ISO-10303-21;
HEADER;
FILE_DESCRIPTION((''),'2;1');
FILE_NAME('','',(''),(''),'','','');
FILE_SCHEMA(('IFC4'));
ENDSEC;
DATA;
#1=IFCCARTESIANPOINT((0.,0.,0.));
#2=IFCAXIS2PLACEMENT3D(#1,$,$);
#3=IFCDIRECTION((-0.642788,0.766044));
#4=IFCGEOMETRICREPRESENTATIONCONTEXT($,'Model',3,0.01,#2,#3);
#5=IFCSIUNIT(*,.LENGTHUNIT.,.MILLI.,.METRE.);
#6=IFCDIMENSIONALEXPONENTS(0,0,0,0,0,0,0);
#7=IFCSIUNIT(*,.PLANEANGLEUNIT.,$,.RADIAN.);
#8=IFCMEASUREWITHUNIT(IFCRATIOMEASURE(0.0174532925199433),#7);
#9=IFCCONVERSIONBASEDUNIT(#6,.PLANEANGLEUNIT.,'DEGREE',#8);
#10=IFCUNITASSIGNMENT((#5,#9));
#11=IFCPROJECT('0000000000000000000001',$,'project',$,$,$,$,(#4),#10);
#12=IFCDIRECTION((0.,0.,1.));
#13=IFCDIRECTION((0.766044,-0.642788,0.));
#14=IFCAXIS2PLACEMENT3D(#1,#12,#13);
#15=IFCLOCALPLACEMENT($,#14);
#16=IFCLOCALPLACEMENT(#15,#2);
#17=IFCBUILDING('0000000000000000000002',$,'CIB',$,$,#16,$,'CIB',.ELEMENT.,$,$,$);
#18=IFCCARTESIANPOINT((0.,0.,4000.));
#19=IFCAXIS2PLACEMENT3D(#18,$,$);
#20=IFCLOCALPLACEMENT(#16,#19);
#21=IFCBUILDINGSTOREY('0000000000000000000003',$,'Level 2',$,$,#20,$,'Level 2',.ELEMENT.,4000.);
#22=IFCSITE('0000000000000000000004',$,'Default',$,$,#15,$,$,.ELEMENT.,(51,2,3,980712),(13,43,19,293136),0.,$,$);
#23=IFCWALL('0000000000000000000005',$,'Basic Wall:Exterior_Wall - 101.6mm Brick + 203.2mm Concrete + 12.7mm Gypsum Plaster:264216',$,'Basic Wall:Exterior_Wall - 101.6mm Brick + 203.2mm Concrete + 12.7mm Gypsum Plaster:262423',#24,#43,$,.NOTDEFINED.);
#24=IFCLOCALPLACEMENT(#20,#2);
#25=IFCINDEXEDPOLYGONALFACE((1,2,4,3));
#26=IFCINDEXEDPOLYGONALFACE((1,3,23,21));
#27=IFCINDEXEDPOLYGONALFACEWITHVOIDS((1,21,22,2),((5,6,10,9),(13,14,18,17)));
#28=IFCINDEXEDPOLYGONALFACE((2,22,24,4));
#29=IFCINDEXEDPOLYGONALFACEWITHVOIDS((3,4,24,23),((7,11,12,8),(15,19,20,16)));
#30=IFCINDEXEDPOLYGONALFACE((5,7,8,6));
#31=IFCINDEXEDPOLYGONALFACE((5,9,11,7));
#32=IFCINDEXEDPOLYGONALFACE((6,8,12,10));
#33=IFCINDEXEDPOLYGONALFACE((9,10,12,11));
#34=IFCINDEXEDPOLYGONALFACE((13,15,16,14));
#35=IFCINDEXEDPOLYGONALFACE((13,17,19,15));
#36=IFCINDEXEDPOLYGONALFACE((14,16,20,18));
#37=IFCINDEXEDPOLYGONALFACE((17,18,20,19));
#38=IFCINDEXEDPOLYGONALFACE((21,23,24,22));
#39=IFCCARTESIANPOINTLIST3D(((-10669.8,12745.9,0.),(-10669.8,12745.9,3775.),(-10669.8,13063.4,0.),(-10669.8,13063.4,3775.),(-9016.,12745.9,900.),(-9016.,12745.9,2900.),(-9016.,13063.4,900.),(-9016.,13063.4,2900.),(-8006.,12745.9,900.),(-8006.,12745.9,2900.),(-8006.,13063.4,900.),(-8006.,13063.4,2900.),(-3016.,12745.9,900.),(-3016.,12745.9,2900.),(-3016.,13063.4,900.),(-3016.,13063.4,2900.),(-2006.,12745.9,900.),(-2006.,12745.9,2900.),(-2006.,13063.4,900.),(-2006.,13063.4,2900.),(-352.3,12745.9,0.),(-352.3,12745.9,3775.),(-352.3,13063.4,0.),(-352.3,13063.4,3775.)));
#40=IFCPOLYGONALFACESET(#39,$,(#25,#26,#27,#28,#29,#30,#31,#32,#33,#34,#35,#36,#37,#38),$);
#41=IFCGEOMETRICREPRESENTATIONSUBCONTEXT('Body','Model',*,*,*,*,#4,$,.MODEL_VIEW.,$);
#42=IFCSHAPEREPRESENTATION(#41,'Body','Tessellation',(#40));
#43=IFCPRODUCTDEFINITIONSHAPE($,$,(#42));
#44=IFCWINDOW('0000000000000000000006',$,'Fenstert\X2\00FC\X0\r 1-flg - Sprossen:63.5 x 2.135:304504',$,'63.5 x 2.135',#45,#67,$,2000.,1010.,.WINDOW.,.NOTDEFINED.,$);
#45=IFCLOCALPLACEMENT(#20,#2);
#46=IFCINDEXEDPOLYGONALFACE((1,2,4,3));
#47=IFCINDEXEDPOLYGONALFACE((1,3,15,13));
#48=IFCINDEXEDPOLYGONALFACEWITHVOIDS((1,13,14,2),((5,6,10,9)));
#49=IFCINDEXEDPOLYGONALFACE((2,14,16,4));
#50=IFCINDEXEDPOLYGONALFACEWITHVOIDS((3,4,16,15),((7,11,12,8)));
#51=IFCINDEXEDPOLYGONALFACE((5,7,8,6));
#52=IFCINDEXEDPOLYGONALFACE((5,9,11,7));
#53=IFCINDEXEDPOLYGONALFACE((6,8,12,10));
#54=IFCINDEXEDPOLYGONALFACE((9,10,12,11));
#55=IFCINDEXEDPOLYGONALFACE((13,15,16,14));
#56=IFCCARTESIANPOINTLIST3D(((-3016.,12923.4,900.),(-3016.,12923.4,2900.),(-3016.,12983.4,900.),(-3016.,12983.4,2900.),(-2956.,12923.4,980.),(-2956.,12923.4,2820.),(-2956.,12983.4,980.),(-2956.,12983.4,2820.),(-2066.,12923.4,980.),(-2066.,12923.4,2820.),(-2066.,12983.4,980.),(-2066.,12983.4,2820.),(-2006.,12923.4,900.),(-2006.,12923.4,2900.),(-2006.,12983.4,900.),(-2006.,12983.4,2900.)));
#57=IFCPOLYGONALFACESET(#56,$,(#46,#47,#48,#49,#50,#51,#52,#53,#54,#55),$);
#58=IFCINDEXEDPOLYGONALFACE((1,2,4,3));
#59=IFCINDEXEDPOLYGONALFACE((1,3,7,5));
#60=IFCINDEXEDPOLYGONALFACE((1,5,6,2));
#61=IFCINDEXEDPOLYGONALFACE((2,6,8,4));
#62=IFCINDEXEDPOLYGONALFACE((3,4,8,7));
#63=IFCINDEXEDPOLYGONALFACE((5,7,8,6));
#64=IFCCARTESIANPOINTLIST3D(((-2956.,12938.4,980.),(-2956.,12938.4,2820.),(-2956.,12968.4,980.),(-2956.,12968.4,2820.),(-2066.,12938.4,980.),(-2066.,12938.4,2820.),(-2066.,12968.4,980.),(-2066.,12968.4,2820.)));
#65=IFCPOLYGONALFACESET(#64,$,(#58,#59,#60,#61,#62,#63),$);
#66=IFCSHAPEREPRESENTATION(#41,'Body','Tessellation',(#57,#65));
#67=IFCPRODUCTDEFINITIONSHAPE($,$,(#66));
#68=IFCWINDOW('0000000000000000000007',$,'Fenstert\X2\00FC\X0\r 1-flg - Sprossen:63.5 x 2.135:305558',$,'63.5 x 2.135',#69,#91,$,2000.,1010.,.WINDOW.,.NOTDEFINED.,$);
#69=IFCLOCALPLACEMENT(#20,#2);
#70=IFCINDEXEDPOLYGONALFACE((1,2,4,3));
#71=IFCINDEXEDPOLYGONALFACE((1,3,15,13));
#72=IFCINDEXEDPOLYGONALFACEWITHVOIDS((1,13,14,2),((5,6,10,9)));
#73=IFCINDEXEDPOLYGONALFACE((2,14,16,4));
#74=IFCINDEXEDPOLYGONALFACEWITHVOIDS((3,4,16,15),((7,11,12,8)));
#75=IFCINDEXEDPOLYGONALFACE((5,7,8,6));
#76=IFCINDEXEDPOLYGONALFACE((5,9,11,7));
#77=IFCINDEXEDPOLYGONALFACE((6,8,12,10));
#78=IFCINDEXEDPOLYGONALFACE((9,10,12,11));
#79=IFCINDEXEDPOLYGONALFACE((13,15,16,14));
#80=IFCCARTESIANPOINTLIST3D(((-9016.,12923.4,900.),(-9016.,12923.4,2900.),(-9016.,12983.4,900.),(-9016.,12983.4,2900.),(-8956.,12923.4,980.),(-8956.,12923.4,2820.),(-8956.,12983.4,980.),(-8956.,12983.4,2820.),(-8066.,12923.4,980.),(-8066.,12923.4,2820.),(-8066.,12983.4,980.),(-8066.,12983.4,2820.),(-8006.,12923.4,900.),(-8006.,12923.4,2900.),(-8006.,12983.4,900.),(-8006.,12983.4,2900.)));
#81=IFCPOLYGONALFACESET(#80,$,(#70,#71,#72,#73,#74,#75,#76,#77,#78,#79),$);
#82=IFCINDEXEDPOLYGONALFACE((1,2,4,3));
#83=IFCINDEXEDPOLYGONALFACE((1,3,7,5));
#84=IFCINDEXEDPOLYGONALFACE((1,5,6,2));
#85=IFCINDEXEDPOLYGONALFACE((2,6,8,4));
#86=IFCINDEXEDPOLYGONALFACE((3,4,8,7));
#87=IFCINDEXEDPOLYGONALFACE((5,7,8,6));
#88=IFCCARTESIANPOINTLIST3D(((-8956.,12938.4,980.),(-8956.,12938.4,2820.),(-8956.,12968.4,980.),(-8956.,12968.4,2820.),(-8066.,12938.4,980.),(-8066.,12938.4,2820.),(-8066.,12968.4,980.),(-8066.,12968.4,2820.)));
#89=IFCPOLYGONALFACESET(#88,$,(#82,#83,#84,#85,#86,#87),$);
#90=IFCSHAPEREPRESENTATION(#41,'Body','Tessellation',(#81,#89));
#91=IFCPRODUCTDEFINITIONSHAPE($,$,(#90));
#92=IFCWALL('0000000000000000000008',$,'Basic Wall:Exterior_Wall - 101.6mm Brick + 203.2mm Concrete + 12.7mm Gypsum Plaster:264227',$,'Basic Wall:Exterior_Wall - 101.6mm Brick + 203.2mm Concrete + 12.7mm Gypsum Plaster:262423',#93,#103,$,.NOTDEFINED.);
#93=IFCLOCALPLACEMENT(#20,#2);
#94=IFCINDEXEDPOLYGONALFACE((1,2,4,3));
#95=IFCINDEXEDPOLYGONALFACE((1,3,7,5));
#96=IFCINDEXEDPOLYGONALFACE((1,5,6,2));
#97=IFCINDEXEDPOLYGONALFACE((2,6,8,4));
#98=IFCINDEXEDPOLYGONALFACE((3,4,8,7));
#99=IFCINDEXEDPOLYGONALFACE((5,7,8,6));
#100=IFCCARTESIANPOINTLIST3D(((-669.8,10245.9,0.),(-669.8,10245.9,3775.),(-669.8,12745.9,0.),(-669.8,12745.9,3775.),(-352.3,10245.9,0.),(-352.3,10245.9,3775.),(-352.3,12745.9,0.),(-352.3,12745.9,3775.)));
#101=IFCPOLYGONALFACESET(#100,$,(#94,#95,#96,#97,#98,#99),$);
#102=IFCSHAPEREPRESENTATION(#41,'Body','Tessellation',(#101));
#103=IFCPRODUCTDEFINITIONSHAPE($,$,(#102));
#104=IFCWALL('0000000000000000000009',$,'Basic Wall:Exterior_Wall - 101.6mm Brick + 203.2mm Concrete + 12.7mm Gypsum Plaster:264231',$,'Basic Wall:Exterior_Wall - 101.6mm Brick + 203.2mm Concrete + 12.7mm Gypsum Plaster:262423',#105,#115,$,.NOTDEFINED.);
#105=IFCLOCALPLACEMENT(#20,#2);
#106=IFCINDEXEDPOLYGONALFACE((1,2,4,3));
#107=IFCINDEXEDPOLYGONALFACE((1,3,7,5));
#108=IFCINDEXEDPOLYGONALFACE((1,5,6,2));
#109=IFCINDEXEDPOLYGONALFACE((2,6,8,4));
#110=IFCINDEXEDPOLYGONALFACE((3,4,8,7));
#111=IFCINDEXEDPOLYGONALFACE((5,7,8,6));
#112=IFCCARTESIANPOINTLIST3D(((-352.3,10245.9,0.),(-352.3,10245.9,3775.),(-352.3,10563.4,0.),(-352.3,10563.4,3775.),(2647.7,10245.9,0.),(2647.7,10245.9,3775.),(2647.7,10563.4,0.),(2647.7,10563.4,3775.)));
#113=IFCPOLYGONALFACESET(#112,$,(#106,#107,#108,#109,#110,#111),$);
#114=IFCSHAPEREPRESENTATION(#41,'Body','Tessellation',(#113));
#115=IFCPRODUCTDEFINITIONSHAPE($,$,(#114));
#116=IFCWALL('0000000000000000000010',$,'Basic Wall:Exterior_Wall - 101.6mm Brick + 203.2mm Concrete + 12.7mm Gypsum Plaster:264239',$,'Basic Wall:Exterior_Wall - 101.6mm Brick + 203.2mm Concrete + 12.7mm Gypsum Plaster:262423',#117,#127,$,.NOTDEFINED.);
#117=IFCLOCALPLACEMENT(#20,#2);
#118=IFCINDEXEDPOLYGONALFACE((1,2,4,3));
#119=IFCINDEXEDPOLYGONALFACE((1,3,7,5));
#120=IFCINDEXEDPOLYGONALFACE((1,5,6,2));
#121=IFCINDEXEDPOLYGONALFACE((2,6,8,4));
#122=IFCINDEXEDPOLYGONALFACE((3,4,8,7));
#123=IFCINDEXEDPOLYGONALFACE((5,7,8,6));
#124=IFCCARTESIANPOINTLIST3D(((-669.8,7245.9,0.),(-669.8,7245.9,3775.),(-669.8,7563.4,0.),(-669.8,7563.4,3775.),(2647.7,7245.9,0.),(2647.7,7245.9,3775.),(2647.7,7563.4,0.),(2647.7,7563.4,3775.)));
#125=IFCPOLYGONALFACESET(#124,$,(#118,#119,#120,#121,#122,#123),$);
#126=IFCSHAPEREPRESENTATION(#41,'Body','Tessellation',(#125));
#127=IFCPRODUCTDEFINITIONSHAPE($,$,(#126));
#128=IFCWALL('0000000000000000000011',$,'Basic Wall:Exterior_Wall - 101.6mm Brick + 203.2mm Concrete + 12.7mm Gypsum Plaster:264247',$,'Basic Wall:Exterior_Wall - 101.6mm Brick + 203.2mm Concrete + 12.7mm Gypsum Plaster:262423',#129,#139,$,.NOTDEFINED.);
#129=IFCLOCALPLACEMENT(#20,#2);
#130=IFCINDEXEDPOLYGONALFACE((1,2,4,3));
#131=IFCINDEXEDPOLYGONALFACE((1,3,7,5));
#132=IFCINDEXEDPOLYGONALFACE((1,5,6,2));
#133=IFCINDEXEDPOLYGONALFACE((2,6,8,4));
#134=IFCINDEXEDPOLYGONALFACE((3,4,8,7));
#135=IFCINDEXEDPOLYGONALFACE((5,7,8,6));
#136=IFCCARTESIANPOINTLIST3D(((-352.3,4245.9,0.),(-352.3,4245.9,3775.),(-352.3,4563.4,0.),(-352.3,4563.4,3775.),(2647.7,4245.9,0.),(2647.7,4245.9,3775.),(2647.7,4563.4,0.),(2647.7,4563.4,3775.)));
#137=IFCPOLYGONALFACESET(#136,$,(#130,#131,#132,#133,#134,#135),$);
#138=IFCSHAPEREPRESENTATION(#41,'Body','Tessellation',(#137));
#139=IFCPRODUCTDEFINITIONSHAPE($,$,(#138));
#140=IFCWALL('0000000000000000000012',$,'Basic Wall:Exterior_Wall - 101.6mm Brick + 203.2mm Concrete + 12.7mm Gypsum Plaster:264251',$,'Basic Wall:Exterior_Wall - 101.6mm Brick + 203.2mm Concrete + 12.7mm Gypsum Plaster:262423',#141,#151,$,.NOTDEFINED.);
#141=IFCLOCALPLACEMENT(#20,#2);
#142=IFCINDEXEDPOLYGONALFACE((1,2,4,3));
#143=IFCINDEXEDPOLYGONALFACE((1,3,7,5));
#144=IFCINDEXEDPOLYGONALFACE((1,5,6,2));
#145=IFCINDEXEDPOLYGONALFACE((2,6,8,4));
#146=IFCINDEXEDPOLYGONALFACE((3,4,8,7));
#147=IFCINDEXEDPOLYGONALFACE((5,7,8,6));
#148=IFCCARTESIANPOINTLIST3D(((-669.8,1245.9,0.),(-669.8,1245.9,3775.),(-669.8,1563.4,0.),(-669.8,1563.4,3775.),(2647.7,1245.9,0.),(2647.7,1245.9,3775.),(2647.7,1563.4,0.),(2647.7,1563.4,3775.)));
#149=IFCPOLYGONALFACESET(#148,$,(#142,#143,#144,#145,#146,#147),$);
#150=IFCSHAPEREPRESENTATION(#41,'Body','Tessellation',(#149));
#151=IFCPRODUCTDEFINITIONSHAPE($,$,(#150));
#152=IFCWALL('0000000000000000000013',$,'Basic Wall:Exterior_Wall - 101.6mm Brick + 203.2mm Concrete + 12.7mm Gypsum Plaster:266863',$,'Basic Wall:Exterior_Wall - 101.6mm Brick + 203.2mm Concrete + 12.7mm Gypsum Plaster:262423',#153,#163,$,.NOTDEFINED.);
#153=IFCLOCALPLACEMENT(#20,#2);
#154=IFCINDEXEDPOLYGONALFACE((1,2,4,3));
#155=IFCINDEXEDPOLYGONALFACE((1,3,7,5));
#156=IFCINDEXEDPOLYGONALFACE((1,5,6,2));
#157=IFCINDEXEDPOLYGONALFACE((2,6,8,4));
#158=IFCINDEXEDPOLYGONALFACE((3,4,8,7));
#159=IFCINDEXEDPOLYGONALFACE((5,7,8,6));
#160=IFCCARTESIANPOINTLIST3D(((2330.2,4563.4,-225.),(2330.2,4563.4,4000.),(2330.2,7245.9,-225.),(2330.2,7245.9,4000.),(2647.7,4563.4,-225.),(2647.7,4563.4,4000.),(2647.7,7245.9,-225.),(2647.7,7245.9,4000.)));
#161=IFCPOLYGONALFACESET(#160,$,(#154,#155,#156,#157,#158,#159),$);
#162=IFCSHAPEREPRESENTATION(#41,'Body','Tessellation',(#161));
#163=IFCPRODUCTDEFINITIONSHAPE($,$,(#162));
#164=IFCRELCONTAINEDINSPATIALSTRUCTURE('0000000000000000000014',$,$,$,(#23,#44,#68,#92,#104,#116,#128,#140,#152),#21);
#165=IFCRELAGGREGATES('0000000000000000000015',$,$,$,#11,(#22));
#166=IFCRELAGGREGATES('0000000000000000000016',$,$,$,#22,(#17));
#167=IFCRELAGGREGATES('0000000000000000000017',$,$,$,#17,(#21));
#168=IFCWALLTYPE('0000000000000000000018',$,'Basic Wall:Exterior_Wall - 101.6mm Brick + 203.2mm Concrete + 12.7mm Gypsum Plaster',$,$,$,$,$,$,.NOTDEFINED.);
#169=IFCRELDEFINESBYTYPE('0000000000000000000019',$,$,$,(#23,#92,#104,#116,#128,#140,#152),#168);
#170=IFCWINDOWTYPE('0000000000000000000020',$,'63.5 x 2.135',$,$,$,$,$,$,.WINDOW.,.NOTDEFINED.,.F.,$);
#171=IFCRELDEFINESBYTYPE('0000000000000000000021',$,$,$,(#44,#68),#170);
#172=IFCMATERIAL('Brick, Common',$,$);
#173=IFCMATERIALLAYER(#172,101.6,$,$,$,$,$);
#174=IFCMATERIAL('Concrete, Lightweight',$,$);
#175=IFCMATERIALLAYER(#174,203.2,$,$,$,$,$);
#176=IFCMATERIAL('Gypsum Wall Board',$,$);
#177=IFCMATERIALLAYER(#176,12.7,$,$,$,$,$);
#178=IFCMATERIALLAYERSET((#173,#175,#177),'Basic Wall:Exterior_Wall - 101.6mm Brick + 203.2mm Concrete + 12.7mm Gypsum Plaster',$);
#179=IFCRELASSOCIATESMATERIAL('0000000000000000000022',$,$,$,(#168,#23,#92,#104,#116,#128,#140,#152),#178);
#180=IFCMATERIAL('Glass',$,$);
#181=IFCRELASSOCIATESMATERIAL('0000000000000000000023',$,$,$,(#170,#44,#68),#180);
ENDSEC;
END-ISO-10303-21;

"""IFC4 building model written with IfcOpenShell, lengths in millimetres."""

from ifc_helpers import new_model, entity, si_unit, converted_unit, direction, frame, frame_2d, origin, origin_2d_with_axis, place, context, subcontext, project, spatial, polyline, rectangle, outline, extrude, clip, bounded_halfspace, source, transform, mapped, material, layer, layer_set, layer_usage, type_object, type_shapes, element, fill, save


model = new_model("IFC4")

# Units and contexts
model_context = context("Model", 3, precision=0.01, world=origin(), true_north=direction((-0.642788, 0.766044)))
body_context = subcontext(model_context, "Body", "Model", "MODEL_VIEW")
ifc_project = project(units=[si_unit("LENGTHUNIT", "METRE", prefix="MILLI"), converted_unit("PLANEANGLEUNIT", "DEGREE", entity("IfcRatioMeasure", 0.0174532925199433), si_unit("PLANEANGLEUNIT", "RADIAN"), dimensions=[0, 0, 0, 0, 0, 0, 0])], contexts=[model_context])

# Site, building, storey
site_placement = place(None, frame((0.0, 0.0, 0.0), z_axis=(0.0, 0.0, 1.0), x_axis=(0.766044, -0.642788, 0.0)))
site = spatial("IfcSite", under=ifc_project, at=site_placement, Name="Default", CompositionType="ELEMENT", RefLatitude=(51, 2, 3, 980712), RefLongitude=(13, 43, 19, 293136), RefElevation=0.0)
building_placement = place(site_placement, origin())
building = spatial("IfcBuilding", under=site, at=building_placement, Name="CIB", LongName="CIB", CompositionType="ELEMENT")
storey_placement = place(building_placement, frame((0.0, 0.0, 4000.0)))
storey = spatial("IfcBuildingStorey", under=building, at=storey_placement, Name="Level 2", LongName="Level 2", CompositionType="ELEMENT", Elevation=4000.0)

# Wall, openings, windows
ifc_material_1 = material(Name="Brick, Common")
ifc_layer_1 = layer(ifc_material_1, 101.6)
ifc_material_2 = material(Name="Concrete, Lightweight")
ifc_layer_2 = layer(ifc_material_2, 203.2)
ifc_material_3 = material(Name="Gypsum Wall Board")
ifc_layer_3 = layer(ifc_material_3, 12.7)
ifc_layer_set_1 = layer_set([ifc_layer_1, ifc_layer_2, ifc_layer_3], Name="Basic Wall:Exterior_Wall - 101.6mm Brick + 203.2mm Concrete + 12.7mm Gypsum Plaster")
ifc_layer_usage_1 = layer_usage(ifc_layer_set_1, "AXIS2", "POSITIVE", -158.8)
wall_type_1 = type_object("IfcWallType", Name="Basic Wall:Exterior_Wall - 101.6mm Brick + 203.2mm Concrete + 12.7mm Gypsum Plaster", PredefinedType="NOTDEFINED", material=ifc_layer_set_1)
wall_1_placement = place(storey_placement, frame((-352.3, 12904.7, 0.0), z_axis=(0.0, 0.0, 1.0), x_axis=(-1.0, 0.0, 0.0)))
wall_1 = element("IfcWall", 1, at=wall_1_placement, inside=storey, type_object=wall_type_1, material=ifc_layer_usage_1, Name="Basic Wall:Exterior_Wall - 101.6mm Brick + 203.2mm Concrete + 12.7mm Gypsum Plaster:264216", ObjectType="Basic Wall:Exterior_Wall - 101.6mm Brick + 203.2mm Concrete + 12.7mm Gypsum Plaster:262423", PredefinedType="NOTDEFINED", context=body_context, shape_type="Clipping", body=[
    clip(extrude(rectangle(XDim=10317.5, YDim=317.5, at=frame_2d((5158.7, 0.0), x_axis=(-1.0, 0.0))), origin(), (0.0, 0.0, 1.0), 3775.0), bounded_halfspace(frame((0.0, -158.7, 3775.0), z_axis=(0.0, 0.0, -1.0), x_axis=(0.0, -1.0, 0.0)), True, frame((0.0, -158.7, 3775.0)), polyline([(0.0, 0.0), (10317.5, 0.0), (10317.5, 317.5), (10000.0, 317.5), (317.5, 317.5), (0.0, 317.5), (0.0, 0.0)]))),
])
opening_1_placement = place(wall_1_placement, frame((1653.7, -158.7, 900.0)))
opening_1 = element("IfcOpeningElement", 2, at=opening_1_placement, cuts=wall_1, ObjectType="Opening", PredefinedType="OPENING", context=body_context, shape_type="SweptSolid", body=[
    extrude(rectangle(XDim=2000.0, YDim=1010.0, at=frame_2d((1000.0, 505.0), x_axis=(1.0, 0.0))), frame((0.0, 0.0, 0.0), z_axis=(0.0, 1.0, 0.0), x_axis=(0.0, 0.0, 1.0)), (0.0, 0.0, 1.0), 317.5),
])
opening_2_placement = place(wall_1_placement, frame((7653.7, -158.7, 900.0)))
opening_2 = element("IfcOpeningElement", 3, at=opening_2_placement, cuts=wall_1, ObjectType="Opening", PredefinedType="OPENING", context=body_context, shape_type="SweptSolid", body=[
    extrude(rectangle(XDim=2000.0, YDim=1010.0, at=frame_2d((1000.0, 505.0), x_axis=(1.0, 0.0))), frame((0.0, 0.0, 0.0), z_axis=(0.0, 1.0, 0.0), x_axis=(0.0, 0.0, 1.0)), (0.0, 0.0, 1.0), 317.5),
])
ifc_material_4 = material(Name="Glass")
window_type = type_object("IfcWindowType", Name="63.5 x 2.135", ParameterTakesPrecedence=False, PartitioningType="NOTDEFINED", PredefinedType="WINDOW", material=ifc_material_4)
shared_shape_1 = source(origin(), body_context, "Body", "SweptSolid", [
    extrude(outline(polyline([(-1000.0, -505.0), (1000.0, -505.0), (1000.0, 505.0), (-1000.0, 505.0), (-1000.0, -505.0)]), holes=[polyline([(-920.0, -445.0), (-920.0, 445.0), (920.0, 445.0), (920.0, -445.0), (-920.0, -445.0)])]), frame((505.0, 177.5, 1000.0), z_axis=(0.0, 1.0, 0.0), x_axis=(0.0, 0.0, -1.0)), (0.0, 0.0, 1.0), 60.0),
    extrude(rectangle(XDim=30.0, YDim=890.0, at=origin_2d_with_axis()), frame((505.0, 207.5, 80.0), z_axis=(0.0, 0.0, 1.0), x_axis=(0.0, 1.0, 0.0)), (0.0, 0.0, 1.0), 1840.0),
])
type_shapes(window_type, [shared_shape_1])
window_1_placement = place(opening_1_placement, frame((1010.0, 317.5, 0.0), z_axis=(0.0, 0.0, 1.0), x_axis=(-1.0, 0.0, 0.0)))
window_1 = element("IfcWindow", 4, at=window_1_placement, inside=storey, type_object=window_type, material=ifc_material_4, Name="Fenstertür 1-flg - Sprossen:63.5 x 2.135:304504", ObjectType="63.5 x 2.135", OverallHeight=2000.0, OverallWidth=1010.0, PartitioningType="NOTDEFINED", PredefinedType="WINDOW", context=body_context, shape_type="MappedRepresentation", body=[
    mapped(shared_shape_1, transform((0.0, 0.0, 0.0), scale=1.0)),
])
fill(opening_1, window_1)
window_2_placement = place(opening_2_placement, frame((1010.0, 317.5, 0.0), z_axis=(0.0, 0.0, 1.0), x_axis=(-1.0, 0.0, 0.0)))
window_2 = element("IfcWindow", 5, at=window_2_placement, inside=storey, type_object=window_type, material=ifc_material_4, Name="Fenstertür 1-flg - Sprossen:63.5 x 2.135:305558", ObjectType="63.5 x 2.135", OverallHeight=2000.0, OverallWidth=1010.0, PartitioningType="NOTDEFINED", PredefinedType="WINDOW", context=body_context, shape_type="MappedRepresentation", body=[
    mapped(shared_shape_1, transform((0.0, 0.0, 0.0), scale=1.0)),
])
fill(opening_2, window_2)

# Walls
ifc_layer_usage_2 = layer_usage(ifc_layer_set_1, "AXIS2", "NEGATIVE", 158.8)
wall_2_placement = place(storey_placement, frame((-511.0, 12745.9, 0.0), z_axis=(0.0, 0.0, 1.0), x_axis=(0.0, -1.0, 0.0)))
element("IfcWall", 6, at=wall_2_placement, inside=storey, type_object=wall_type_1, material=ifc_layer_usage_2, Name="Basic Wall:Exterior_Wall - 101.6mm Brick + 203.2mm Concrete + 12.7mm Gypsum Plaster:264227", ObjectType="Basic Wall:Exterior_Wall - 101.6mm Brick + 203.2mm Concrete + 12.7mm Gypsum Plaster:262423", PredefinedType="NOTDEFINED", context=body_context, shape_type="Clipping", body=[
    clip(extrude(rectangle(XDim=2500.0, YDim=317.5, at=frame_2d((1250.0, 0.0), x_axis=(-1.0, 0.0))), origin(), (0.0, 0.0, 1.0), 3775.0), bounded_halfspace(frame((0.0, -158.8, 3775.0), z_axis=(0.0, 0.0, -1.0), x_axis=(-1.0, 0.0, 0.0)), True, frame((0.0, -158.8, 3775.0)), polyline([(0.0, 0.0), (2500.0, 0.0), (2500.0, 317.5), (2182.5, 317.5), (0.0, 317.5), (0.0, 0.0)]))),
])
ifc_layer_usage_3 = layer_usage(ifc_layer_set_1, "AXIS2", "NEGATIVE", 158.8)
wall_3_placement = place(storey_placement, frame((-352.3, 10404.7, 0.0)))
element("IfcWall", 7, at=wall_3_placement, inside=storey, type_object=wall_type_1, material=ifc_layer_usage_3, Name="Basic Wall:Exterior_Wall - 101.6mm Brick + 203.2mm Concrete + 12.7mm Gypsum Plaster:264231", ObjectType="Basic Wall:Exterior_Wall - 101.6mm Brick + 203.2mm Concrete + 12.7mm Gypsum Plaster:262423", PredefinedType="NOTDEFINED", context=body_context, shape_type="Clipping", body=[
    clip(extrude(rectangle(XDim=3000.0, YDim=317.5, at=frame_2d((1500.0, 0.0), x_axis=(-1.0, 0.0))), origin(), (0.0, 0.0, 1.0), 3775.0), bounded_halfspace(frame((0.0, -158.7, 3775.0), z_axis=(0.0, 0.0, -1.0), x_axis=(0.0, 1.0, 0.0)), True, frame((0.0, -158.7, 3775.0)), polyline([(0.0, 0.0), (2682.5, 0.0), (3000.0, 0.0), (3000.0, 317.5), (0.0, 317.5), (0.0, 0.0)]))),
])
ifc_layer_usage_4 = layer_usage(ifc_layer_set_1, "AXIS2", "POSITIVE", -158.8)
wall_4_placement = place(storey_placement, frame((-669.8, 7404.7, 0.0)))
element("IfcWall", 8, at=wall_4_placement, inside=storey, type_object=wall_type_1, material=ifc_layer_usage_4, Name="Basic Wall:Exterior_Wall - 101.6mm Brick + 203.2mm Concrete + 12.7mm Gypsum Plaster:264239", ObjectType="Basic Wall:Exterior_Wall - 101.6mm Brick + 203.2mm Concrete + 12.7mm Gypsum Plaster:262423", PredefinedType="NOTDEFINED", context=body_context, shape_type="Clipping", body=[
    clip(extrude(rectangle(XDim=3317.5, YDim=317.5, at=frame_2d((1658.8, 0.0), x_axis=(-1.0, 0.0))), origin(), (0.0, 0.0, 1.0), 3775.0), bounded_halfspace(frame((0.0, -158.8, 3775.0), z_axis=(0.0, 0.0, -1.0), x_axis=(0.0, 1.0, 0.0)), True, frame((0.0, -158.8, 3775.0)), polyline([(0.0, 0.0), (317.5, 0.0), (3317.5, 0.0), (3317.5, 317.5), (3000.0, 317.5), (0.0, 317.5), (0.0, 0.0)]))),
])
ifc_layer_usage_5 = layer_usage(ifc_layer_set_1, "AXIS2", "POSITIVE", -158.8)
wall_5_placement = place(storey_placement, frame((2647.7, 4404.7, 0.0), z_axis=(0.0, 0.0, 1.0), x_axis=(-1.0, 0.0, 0.0)))
element("IfcWall", 9, at=wall_5_placement, inside=storey, type_object=wall_type_1, material=ifc_layer_usage_5, Name="Basic Wall:Exterior_Wall - 101.6mm Brick + 203.2mm Concrete + 12.7mm Gypsum Plaster:264247", ObjectType="Basic Wall:Exterior_Wall - 101.6mm Brick + 203.2mm Concrete + 12.7mm Gypsum Plaster:262423", PredefinedType="NOTDEFINED", context=body_context, shape_type="Clipping", body=[
    clip(extrude(rectangle(XDim=3000.0, YDim=317.5, at=frame_2d((1500.0, 0.0), x_axis=(-1.0, 0.0))), origin(), (0.0, 0.0, 1.0), 3775.0), bounded_halfspace(frame((0.0, -158.8, 3775.0), z_axis=(0.0, 0.0, -1.0), x_axis=(0.0, -1.0, 0.0)), True, frame((0.0, -158.8, 3775.0)), polyline([(0.0, 0.0), (3000.0, 0.0), (3000.0, 317.5), (317.5, 317.5), (0.0, 317.5), (0.0, 0.0)]))),
])
ifc_layer_usage_6 = layer_usage(ifc_layer_set_1, "AXIS2", "NEGATIVE", 158.8)
wall_6_placement = place(storey_placement, frame((2647.7, 1404.7, 0.0), z_axis=(0.0, 0.0, 1.0), x_axis=(-1.0, 0.0, 0.0)))
element("IfcWall", 10, at=wall_6_placement, inside=storey, type_object=wall_type_1, material=ifc_layer_usage_6, Name="Basic Wall:Exterior_Wall - 101.6mm Brick + 203.2mm Concrete + 12.7mm Gypsum Plaster:264251", ObjectType="Basic Wall:Exterior_Wall - 101.6mm Brick + 203.2mm Concrete + 12.7mm Gypsum Plaster:262423", PredefinedType="NOTDEFINED", context=body_context, shape_type="Clipping", body=[
    clip(extrude(rectangle(XDim=3317.5, YDim=317.5, at=frame_2d((1658.7, 0.0), x_axis=(-1.0, 0.0))), origin(), (0.0, 0.0, 1.0), 3775.0), bounded_halfspace(frame((0.0, -158.8, 3775.0), z_axis=(0.0, 0.0, -1.0), x_axis=(0.0, -1.0, 0.0)), True, frame((0.0, -158.8, 3775.0)), polyline([(0.0, 0.0), (317.5, 0.0), (3317.5, 0.0), (3317.5, 317.5), (3000.0, 317.5), (0.0, 317.5), (0.0, 0.0)]))),
])
ifc_layer_usage_7 = layer_usage(ifc_layer_set_1, "AXIS2", "NEGATIVE", 158.8)
wall_7_placement = place(storey_placement, frame((2489.0, 7245.9, -225.0), z_axis=(0.0, 0.0, 1.0), x_axis=(0.0, -1.0, 0.0)))
element("IfcWall", 11, at=wall_7_placement, inside=storey, type_object=wall_type_1, material=ifc_layer_usage_7, Name="Basic Wall:Exterior_Wall - 101.6mm Brick + 203.2mm Concrete + 12.7mm Gypsum Plaster:266863", ObjectType="Basic Wall:Exterior_Wall - 101.6mm Brick + 203.2mm Concrete + 12.7mm Gypsum Plaster:262423", PredefinedType="NOTDEFINED", context=body_context, shape_type="SweptSolid", body=[
    extrude(rectangle(XDim=2682.5, YDim=317.5, at=frame_2d((1341.2, 0.0), x_axis=(-1.0, 0.0))), origin(), (0.0, 0.0, 1.0), 4225.0),
])

save(model, "model.ifc")
